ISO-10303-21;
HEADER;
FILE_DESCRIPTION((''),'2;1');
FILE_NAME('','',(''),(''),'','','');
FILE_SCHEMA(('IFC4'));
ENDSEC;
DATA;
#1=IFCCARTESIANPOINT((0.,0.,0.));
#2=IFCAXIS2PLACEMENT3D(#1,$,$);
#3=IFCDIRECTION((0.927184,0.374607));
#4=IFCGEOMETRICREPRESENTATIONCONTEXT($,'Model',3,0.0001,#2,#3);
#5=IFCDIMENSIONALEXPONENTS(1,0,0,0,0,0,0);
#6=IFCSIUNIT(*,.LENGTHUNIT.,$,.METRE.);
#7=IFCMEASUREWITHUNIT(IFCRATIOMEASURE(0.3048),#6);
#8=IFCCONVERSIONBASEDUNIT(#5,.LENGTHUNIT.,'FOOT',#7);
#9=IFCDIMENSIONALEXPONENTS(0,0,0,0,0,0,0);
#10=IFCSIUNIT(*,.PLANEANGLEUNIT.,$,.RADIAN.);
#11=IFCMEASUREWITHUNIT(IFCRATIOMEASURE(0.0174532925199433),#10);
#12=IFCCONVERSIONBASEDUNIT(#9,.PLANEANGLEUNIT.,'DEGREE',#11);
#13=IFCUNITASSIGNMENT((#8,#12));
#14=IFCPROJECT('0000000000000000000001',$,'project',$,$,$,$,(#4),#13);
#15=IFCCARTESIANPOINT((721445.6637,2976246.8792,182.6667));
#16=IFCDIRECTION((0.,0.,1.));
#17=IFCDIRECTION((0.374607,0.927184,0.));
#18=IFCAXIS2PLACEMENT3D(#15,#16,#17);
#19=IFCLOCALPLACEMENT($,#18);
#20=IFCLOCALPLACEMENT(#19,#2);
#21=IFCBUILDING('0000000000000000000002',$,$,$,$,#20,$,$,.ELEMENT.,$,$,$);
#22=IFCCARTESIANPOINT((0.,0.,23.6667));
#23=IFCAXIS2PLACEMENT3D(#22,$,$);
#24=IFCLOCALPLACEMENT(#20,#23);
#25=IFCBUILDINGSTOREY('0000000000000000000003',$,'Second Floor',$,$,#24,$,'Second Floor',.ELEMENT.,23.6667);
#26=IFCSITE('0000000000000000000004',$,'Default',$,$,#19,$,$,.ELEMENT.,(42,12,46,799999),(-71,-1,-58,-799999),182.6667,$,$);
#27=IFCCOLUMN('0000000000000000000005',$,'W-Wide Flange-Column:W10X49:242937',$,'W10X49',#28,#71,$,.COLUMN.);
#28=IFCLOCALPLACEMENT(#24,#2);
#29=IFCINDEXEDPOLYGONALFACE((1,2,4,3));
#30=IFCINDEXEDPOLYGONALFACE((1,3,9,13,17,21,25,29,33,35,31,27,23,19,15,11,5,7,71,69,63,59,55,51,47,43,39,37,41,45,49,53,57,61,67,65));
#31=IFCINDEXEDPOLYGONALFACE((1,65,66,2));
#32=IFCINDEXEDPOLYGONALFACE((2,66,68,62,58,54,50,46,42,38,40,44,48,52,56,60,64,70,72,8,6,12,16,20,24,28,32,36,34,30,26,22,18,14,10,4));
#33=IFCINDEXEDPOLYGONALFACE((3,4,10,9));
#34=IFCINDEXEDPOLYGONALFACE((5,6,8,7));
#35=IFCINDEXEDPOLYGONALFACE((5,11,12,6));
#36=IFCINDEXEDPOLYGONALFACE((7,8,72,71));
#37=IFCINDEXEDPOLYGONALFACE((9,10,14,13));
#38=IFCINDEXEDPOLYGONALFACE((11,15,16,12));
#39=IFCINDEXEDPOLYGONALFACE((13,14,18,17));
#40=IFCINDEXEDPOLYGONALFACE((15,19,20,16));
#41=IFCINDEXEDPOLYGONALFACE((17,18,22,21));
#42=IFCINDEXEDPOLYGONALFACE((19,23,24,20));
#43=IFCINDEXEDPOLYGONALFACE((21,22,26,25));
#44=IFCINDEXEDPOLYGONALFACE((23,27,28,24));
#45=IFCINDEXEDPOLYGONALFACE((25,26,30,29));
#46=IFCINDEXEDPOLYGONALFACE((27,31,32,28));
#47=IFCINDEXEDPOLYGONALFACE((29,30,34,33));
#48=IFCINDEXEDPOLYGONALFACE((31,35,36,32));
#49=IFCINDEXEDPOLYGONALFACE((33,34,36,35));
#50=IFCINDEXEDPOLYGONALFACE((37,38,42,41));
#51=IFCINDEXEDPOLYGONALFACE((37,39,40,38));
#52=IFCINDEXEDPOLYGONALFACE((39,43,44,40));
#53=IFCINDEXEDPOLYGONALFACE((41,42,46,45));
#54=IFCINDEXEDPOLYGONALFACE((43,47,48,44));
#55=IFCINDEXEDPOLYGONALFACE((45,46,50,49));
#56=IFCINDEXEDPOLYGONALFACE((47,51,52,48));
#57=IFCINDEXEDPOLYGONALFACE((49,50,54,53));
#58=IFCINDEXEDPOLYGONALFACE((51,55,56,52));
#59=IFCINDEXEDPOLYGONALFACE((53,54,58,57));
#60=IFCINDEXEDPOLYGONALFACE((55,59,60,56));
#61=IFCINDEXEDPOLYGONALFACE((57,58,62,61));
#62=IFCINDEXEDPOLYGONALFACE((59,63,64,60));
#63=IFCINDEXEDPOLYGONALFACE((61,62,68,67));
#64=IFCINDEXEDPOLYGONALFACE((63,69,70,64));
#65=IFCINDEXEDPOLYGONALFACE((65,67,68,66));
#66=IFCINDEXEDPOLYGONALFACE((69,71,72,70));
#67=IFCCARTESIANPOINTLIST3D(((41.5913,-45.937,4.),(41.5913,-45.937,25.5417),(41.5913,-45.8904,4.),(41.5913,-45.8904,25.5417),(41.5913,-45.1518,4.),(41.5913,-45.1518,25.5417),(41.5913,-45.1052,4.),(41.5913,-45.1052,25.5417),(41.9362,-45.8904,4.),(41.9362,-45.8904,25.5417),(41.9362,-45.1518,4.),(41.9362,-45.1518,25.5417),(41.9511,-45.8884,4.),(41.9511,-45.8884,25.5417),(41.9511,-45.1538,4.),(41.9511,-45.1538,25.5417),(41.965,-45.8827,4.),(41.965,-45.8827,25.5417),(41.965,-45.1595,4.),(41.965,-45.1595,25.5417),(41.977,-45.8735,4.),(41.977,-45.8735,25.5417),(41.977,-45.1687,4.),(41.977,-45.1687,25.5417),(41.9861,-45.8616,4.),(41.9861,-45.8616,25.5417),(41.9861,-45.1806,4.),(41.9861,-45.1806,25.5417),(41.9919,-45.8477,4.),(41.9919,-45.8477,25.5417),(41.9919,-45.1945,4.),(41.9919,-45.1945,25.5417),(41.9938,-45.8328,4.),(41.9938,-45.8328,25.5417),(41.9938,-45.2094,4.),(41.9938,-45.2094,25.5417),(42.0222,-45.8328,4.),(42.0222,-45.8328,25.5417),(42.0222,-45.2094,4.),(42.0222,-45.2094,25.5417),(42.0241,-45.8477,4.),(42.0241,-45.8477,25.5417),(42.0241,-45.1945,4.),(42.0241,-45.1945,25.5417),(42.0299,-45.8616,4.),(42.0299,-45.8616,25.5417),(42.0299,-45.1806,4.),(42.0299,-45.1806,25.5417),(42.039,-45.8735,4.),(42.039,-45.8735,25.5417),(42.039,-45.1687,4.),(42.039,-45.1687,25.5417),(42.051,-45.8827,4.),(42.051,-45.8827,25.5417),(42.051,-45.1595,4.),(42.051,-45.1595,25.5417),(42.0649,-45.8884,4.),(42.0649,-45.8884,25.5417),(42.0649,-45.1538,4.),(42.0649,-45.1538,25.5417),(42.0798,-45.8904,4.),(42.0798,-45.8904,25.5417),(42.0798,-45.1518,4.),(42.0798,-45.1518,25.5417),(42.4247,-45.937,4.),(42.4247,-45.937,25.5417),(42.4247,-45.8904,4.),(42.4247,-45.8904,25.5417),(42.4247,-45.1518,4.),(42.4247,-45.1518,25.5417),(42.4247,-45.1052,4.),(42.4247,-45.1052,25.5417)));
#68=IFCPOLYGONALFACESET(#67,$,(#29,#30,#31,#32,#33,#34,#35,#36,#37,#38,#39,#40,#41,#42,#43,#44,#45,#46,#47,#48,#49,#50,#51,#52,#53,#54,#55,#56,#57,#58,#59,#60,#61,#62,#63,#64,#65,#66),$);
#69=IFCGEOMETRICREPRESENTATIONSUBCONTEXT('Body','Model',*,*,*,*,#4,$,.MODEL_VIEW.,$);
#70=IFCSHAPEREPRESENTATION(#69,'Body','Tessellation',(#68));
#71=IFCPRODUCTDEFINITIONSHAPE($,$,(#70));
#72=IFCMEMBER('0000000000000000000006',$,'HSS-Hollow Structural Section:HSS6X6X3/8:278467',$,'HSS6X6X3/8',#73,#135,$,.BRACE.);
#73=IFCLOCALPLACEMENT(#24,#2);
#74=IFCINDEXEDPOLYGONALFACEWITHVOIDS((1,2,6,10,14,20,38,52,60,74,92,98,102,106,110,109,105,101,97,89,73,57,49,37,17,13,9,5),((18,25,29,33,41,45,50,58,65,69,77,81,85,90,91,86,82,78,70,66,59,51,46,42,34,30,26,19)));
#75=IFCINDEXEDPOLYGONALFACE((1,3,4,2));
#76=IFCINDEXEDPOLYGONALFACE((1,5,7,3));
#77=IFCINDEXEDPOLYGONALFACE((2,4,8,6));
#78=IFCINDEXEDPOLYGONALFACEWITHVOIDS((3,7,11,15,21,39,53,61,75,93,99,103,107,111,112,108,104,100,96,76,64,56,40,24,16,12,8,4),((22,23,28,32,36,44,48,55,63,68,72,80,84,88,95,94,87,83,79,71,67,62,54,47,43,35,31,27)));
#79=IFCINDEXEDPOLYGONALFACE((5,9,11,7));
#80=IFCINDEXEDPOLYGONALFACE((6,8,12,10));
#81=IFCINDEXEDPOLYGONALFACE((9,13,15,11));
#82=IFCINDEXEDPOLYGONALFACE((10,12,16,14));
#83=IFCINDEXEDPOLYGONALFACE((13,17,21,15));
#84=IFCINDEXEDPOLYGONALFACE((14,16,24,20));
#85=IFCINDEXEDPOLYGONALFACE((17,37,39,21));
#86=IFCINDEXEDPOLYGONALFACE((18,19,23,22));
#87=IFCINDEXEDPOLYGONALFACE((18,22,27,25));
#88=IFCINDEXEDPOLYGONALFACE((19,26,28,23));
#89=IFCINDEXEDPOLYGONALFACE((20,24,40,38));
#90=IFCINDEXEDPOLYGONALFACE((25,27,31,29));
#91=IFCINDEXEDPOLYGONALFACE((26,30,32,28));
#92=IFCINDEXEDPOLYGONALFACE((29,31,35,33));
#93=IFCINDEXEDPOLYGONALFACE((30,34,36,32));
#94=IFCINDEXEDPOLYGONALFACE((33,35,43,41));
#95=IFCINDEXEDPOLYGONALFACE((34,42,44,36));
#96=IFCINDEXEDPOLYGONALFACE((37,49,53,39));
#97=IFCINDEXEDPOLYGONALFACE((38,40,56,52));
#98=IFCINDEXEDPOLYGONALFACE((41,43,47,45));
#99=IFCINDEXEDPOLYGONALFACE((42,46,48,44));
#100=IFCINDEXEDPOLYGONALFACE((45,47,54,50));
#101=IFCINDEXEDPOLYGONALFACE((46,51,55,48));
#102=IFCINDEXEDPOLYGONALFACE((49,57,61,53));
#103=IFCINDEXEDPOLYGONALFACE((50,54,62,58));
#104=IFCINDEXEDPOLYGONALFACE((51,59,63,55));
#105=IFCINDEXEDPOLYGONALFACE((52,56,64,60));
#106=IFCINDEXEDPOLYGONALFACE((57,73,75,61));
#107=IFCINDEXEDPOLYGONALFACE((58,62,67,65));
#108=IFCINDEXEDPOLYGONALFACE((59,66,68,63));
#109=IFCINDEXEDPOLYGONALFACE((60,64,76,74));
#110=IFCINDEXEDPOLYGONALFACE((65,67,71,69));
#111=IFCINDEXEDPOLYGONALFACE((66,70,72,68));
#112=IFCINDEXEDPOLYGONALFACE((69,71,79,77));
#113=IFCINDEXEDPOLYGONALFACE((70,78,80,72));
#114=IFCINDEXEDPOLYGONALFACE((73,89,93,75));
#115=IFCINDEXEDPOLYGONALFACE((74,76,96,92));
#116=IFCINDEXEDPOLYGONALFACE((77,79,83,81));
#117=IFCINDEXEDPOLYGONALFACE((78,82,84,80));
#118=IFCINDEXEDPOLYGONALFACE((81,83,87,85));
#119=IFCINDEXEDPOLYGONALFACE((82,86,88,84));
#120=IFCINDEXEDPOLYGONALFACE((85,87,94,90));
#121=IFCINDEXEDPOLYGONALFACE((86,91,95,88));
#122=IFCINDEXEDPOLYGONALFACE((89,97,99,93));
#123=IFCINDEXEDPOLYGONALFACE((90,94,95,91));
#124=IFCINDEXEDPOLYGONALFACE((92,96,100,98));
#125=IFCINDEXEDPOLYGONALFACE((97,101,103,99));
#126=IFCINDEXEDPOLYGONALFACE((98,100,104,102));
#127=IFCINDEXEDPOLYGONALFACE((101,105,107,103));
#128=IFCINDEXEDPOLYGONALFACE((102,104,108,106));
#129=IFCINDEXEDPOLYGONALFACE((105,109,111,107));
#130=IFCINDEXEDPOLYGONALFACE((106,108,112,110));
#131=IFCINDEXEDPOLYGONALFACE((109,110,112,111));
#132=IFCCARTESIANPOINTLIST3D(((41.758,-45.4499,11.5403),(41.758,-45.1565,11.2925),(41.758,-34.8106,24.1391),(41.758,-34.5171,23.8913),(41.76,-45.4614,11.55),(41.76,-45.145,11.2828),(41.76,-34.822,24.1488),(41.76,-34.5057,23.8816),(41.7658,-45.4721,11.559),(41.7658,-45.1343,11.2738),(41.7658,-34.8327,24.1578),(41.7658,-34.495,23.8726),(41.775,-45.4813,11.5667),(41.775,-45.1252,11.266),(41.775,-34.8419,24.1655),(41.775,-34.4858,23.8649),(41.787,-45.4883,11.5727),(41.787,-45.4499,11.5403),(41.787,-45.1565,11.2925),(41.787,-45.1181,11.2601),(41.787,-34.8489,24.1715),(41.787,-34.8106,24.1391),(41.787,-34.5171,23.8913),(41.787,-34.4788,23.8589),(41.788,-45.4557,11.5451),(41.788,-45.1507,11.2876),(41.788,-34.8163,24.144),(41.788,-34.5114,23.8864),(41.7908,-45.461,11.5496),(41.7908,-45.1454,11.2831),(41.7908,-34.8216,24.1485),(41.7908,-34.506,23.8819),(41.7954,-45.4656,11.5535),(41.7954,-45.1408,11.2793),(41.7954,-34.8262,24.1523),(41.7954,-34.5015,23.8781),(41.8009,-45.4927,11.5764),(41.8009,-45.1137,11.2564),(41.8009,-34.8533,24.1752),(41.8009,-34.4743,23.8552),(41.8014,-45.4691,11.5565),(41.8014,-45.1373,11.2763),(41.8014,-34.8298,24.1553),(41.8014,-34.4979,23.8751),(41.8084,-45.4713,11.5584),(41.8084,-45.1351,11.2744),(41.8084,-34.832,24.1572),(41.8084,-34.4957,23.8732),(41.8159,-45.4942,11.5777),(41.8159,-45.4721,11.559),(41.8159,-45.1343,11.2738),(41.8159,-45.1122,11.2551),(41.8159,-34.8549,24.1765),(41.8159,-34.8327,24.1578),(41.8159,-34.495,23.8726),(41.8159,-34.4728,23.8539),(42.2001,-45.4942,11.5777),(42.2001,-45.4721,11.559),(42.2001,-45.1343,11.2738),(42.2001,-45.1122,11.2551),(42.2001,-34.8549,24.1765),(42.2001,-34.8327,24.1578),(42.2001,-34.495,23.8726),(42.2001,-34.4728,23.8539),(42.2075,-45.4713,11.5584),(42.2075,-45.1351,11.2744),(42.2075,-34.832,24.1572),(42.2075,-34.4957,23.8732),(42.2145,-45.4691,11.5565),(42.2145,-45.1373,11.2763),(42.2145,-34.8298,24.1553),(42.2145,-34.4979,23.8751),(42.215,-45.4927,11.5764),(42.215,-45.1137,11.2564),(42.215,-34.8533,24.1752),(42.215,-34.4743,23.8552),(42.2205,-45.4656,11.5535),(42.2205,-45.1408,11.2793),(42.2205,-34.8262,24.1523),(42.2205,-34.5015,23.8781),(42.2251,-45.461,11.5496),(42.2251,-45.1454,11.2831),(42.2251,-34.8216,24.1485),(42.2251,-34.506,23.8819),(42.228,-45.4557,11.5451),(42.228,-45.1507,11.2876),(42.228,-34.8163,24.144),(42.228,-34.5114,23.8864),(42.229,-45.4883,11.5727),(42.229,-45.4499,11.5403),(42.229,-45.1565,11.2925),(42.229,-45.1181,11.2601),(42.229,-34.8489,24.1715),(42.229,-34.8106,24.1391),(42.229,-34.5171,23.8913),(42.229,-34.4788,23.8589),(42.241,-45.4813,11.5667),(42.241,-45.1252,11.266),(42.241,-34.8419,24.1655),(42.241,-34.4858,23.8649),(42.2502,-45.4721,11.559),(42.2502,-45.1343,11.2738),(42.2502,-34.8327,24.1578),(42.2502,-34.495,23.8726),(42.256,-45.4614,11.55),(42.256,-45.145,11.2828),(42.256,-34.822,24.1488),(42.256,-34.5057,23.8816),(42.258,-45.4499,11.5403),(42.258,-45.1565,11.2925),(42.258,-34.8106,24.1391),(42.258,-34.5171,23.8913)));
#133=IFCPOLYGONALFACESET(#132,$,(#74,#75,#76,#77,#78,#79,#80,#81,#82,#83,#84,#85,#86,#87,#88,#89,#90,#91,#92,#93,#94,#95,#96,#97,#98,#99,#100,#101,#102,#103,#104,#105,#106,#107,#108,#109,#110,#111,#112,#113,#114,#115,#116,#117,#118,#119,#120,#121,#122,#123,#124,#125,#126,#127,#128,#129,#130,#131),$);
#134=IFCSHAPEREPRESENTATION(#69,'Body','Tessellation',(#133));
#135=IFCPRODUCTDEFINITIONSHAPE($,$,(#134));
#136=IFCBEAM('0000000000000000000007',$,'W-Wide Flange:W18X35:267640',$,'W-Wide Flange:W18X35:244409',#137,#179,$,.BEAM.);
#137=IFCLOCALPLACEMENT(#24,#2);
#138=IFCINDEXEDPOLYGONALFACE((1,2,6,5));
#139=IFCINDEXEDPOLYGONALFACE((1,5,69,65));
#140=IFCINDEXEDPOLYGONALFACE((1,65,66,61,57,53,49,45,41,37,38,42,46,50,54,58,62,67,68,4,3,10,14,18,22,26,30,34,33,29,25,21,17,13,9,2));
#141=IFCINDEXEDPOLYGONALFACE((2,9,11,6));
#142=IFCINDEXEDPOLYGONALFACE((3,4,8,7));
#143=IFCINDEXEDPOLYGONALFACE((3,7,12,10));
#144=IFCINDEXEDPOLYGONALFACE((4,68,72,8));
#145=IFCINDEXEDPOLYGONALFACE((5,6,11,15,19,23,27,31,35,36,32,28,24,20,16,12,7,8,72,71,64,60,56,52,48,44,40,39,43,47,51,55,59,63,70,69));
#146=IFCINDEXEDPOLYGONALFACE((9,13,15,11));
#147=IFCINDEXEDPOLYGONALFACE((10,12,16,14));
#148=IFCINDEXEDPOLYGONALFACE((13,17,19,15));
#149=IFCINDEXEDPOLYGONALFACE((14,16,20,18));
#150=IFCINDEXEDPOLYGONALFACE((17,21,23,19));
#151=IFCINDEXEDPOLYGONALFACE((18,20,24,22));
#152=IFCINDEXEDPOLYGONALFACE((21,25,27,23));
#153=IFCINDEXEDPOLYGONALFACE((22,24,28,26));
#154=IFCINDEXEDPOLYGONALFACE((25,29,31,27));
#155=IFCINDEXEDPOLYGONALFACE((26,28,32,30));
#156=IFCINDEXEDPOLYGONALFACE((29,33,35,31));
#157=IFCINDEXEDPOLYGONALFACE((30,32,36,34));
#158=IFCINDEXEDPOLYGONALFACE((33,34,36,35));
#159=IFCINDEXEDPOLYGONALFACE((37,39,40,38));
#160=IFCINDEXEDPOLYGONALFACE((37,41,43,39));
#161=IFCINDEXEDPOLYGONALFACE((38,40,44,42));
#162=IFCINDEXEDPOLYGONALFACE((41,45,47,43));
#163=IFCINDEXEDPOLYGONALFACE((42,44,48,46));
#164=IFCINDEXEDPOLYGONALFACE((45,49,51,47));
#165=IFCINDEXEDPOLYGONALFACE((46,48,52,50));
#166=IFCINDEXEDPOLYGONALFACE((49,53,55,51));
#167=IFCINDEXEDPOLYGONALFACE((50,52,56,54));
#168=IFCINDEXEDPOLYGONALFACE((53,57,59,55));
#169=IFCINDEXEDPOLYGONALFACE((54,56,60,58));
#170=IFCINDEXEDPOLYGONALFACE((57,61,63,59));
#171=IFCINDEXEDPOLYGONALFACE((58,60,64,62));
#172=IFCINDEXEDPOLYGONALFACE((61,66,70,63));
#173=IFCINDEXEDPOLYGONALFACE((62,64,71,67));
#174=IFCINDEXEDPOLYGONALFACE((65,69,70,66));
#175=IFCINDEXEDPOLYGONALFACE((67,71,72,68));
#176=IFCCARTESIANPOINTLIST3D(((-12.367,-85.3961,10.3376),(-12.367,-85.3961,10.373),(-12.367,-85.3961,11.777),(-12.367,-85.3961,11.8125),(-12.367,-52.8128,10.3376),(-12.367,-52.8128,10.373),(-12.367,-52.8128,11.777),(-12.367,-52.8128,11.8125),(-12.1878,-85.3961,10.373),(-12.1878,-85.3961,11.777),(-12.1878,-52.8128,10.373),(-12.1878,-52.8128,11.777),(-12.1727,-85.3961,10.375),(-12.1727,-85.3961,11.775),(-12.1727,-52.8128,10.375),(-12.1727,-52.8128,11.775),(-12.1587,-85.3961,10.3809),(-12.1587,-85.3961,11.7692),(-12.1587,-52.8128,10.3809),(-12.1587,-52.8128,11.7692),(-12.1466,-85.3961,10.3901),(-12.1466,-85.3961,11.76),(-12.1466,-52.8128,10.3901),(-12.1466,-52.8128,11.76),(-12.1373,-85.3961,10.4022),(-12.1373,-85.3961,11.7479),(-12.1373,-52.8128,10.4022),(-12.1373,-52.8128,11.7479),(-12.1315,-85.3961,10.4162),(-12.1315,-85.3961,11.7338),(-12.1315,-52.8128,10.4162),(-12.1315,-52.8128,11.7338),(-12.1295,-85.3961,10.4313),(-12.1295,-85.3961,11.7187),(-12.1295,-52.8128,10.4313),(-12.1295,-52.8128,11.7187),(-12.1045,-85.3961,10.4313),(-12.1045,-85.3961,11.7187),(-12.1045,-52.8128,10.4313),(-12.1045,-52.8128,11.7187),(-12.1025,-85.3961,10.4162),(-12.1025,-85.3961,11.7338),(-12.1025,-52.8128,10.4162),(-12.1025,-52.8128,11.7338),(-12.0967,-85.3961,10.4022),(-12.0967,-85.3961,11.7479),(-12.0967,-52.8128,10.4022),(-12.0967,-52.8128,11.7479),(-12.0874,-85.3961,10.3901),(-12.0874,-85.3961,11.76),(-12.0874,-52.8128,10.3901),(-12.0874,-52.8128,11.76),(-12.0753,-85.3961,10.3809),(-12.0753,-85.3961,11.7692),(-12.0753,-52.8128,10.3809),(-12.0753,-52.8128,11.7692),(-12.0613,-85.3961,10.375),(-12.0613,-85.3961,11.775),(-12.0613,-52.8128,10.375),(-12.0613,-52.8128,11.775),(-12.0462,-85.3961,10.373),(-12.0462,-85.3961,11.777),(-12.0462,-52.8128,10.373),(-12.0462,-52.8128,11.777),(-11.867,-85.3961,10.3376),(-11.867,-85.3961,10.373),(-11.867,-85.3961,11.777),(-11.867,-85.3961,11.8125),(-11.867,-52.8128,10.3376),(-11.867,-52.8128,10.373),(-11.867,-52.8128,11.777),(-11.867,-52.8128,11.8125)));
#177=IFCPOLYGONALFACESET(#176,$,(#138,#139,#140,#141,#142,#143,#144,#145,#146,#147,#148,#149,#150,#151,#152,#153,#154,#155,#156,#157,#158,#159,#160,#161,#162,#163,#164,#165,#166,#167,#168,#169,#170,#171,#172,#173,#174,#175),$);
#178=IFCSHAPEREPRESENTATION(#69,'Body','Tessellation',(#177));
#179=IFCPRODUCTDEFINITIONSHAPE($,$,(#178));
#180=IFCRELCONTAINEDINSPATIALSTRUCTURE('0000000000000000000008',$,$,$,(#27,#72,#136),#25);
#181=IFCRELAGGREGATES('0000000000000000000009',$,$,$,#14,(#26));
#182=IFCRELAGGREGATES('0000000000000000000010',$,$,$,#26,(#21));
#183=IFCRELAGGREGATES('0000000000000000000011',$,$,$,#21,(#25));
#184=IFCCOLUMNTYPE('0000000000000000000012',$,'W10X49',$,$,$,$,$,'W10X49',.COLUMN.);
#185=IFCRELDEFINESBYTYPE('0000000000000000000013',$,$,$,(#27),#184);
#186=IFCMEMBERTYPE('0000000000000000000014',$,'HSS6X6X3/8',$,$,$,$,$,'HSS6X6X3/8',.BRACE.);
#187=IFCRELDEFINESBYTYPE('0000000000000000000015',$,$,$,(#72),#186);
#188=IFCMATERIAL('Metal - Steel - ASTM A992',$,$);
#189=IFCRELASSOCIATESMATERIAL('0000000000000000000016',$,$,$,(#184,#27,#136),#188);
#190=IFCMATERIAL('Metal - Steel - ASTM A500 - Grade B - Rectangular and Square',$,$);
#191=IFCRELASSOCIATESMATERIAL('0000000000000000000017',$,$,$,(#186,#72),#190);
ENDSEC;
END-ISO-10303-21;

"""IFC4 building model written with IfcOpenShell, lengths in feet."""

from ifc_helpers import new_model, entity, si_unit, converted_unit, direction, frame, frame_2d, origin, place, context, subcontext, project, spatial, polyline, circle_curve, parameter, trimmed, segment, composite_curve, i_section, outline, extrude, source, transform, mapped, material, type_object, type_shapes, element, save


model = new_model("IFC4")

# Units and contexts
model_context = context("Model", 3, precision=0.0001, world=origin(), true_north=direction((0.927184, 0.374607)))
body_context = subcontext(model_context, "Body", "Model", "MODEL_VIEW")
ifc_project = project(units=[converted_unit("LENGTHUNIT", "FOOT", entity("IfcRatioMeasure", 0.3048), si_unit("LENGTHUNIT", "METRE"), dimensions=[1, 0, 0, 0, 0, 0, 0]), converted_unit("PLANEANGLEUNIT", "DEGREE", entity("IfcRatioMeasure", 0.0174532925199433), si_unit("PLANEANGLEUNIT", "RADIAN"), dimensions=[0, 0, 0, 0, 0, 0, 0])], contexts=[model_context])

# Site, building, storey
site_placement = place(None, frame((721445.6637, 2976246.8792, 182.6667), z_axis=(0.0, 0.0, 1.0), x_axis=(0.374607, 0.927184, 0.0)))
site = spatial("IfcSite", under=ifc_project, at=site_placement, Name="Default", CompositionType="ELEMENT", RefLatitude=(42, 12, 46, 799999), RefLongitude=(-71, -1, -58, -799999), RefElevation=182.6667)
building_placement = place(site_placement, origin())
building = spatial("IfcBuilding", under=site, at=building_placement, CompositionType="ELEMENT")
storey_placement = place(building_placement, frame((0.0, 0.0, 23.6667)))
storey = spatial("IfcBuildingStorey", under=building, at=storey_placement, Name="Second Floor", LongName="Second Floor", CompositionType="ELEMENT", Elevation=23.6667)

# Column
ifc_material_1 = material(Name="Metal - Steel - ASTM A992")
column_type = type_object("IfcColumnType", Name="W10X49", ElementType="W10X49", PredefinedType="COLUMN", material=ifc_material_1)
shared_shape_1 = source(origin(), body_context, "Body", "SweptSolid", [
    extrude(i_section(OverallWidth=0.8333, OverallDepth=0.8317, WebThickness=0.0283, FlangeThickness=0.0465, FilletRadius=0.0576, at=frame_2d((0.0, 0.0), x_axis=(0.0, 1.0))), frame((0.0, 0.0, 27.6667), z_axis=(0.0, 0.0, 1.0), x_axis=(0.0, -1.0, 0.0)), (0.0, 0.0, 1.0), 21.5417),
])
type_shapes(column_type, [shared_shape_1])
for number, where, z_axis, x_axis, name in (
    (1, (42.008, -45.5211, -23.6667), (0.0, 0.0, 1.0), (-1.0, 0.0, 0.0), "W-Wide Flange-Column:W10X49:242937"),
):
    element("IfcColumn", number, at=place(storey_placement, frame(where, z_axis=z_axis, x_axis=x_axis)), inside=storey, type_object=column_type, material=ifc_material_1, Name=name, ObjectType="W10X49", PredefinedType="COLUMN", context=body_context, shape_type="MappedRepresentation", body=[
        mapped(shared_shape_1, transform((0.0, 0.0, 0.0), scale=1.0)),
    ])

# Member
ifc_material_2 = material(Name="Metal - Steel - ASTM A500 - Grade B - Rectangular and Square")
member_type = type_object("IfcMemberType", Name="HSS6X6X3/8", ElementType="HSS6X6X3/8", PredefinedType="BRACE", material=ifc_material_2)
shared_shape_2 = source(origin(), body_context, "Body", "SweptSolid", [
    extrude(outline(composite_curve([segment(trimmed(circle_curve(frame_2d((-0.1921, -0.1921), x_axis=(1.0, 0.0)), 0.0579), [parameter(180.0)], [parameter(270.0)], True, "PARAMETER"), True, "CONTINUOUS"), segment(polyline([(-0.1921, -0.25), (0.1921, -0.25)]), True, "CONTINUOUS"), segment(trimmed(circle_curve(frame_2d((0.1921, -0.1921), x_axis=(1.0, 0.0)), 0.0579), [parameter(270.0)], [parameter(0.0)], True, "PARAMETER"), True, "CONTINUOUS"), segment(polyline([(0.25, -0.1921), (0.25, 0.1921)]), True, "CONTINUOUS"), segment(trimmed(circle_curve(frame_2d((0.1921, 0.1921), x_axis=(1.0, 0.0)), 0.0579), [parameter(360.0)], [parameter(90.0)], True, "PARAMETER"), True, "CONTINUOUS"), segment(polyline([(0.1921, 0.25), (-0.1921, 0.25)]), True, "CONTINUOUS"), segment(trimmed(circle_curve(frame_2d((-0.1921, 0.1921), x_axis=(1.0, 0.0)), 0.0579), [parameter(90.0)], [parameter(180.0)], True, "PARAMETER"), True, "CONTINUOUS"), segment(polyline([(-0.25, 0.1921), (-0.25, -0.1921)]), True, "CONTINUOUS")], self_intersect=False), holes=[composite_curve([segment(polyline([(0.1921, -0.221), (-0.1921, -0.221)]), True, "CONTINUOUS"), segment(trimmed(circle_curve(frame_2d((-0.1921, -0.1921), x_axis=(1.0, 0.0)), 0.029), [parameter(180.0)], [parameter(270.0)], True, "PARAMETER"), False, "CONTINUOUS"), segment(polyline([(-0.221, -0.1921), (-0.221, 0.1921)]), True, "CONTINUOUS"), segment(trimmed(circle_curve(frame_2d((-0.1921, 0.1921), x_axis=(1.0, 0.0)), 0.029), [parameter(90.0)], [parameter(180.0)], True, "PARAMETER"), False, "CONTINUOUS"), segment(polyline([(-0.1921, 0.221), (0.1921, 0.221)]), True, "CONTINUOUS"), segment(trimmed(circle_curve(frame_2d((0.1921, 0.1921), x_axis=(1.0, 0.0)), 0.029), [parameter(0.0)], [parameter(90.0)], True, "PARAMETER"), False, "CONTINUOUS"), segment(polyline([(0.221, 0.1921), (0.221, -0.1921)]), True, "CONTINUOUS"), segment(trimmed(circle_curve(frame_2d((0.1921, -0.1921), x_axis=(1.0, 0.0)), 0.029), [parameter(270.0)], [parameter(0.0)], True, "PARAMETER"), False, "CONTINUOUS")], self_intersect=False)]), frame((-8.6389, 0.0, 0.0), z_axis=(1.0, 0.0, 0.0), x_axis=(0.0, -1.0, 0.0)), (0.0, 0.0, 1.0), 16.4902),
])
type_shapes(member_type, [shared_shape_2])
member_placement = place(storey_placement, frame((42.008, -39.7294, 18.0167), z_axis=(0.0, -0.764019, 0.645194), x_axis=(0.0, 0.645194, 0.764019)))
element("IfcMember", 2, at=member_placement, inside=storey, type_object=member_type, material=ifc_material_2, Name="HSS-Hollow Structural Section:HSS6X6X3/8:278467", ObjectType="HSS6X6X3/8", PredefinedType="BRACE", context=body_context, shape_type="MappedRepresentation", body=[
    mapped(shared_shape_2, transform((0.0, 0.0, 0.0), scale=1.0)),
])

# Beam
beam_1_placement = place(storey_placement, frame((-12.117, -52.3544, 11.8125), z_axis=(0.0, 0.0, 1.0), x_axis=(0.0, -1.0, 0.0)))
element("IfcBeam", 3, at=beam_1_placement, inside=storey, material=ifc_material_1, Name="W-Wide Flange:W18X35:267640", ObjectType="W-Wide Flange:W18X35:244409", PredefinedType="BEAM", context=body_context, shape_type="SweptSolid", body=[
    extrude(i_section(OverallWidth=0.5, OverallDepth=1.4749, WebThickness=0.0251, FlangeThickness=0.0355, FilletRadius=0.0583, at=frame_2d((0.0, 0.0), x_axis=(0.0, 1.0))), frame((0.4583, 0.0, -0.7375), z_axis=(1.0, 0.0, 0.0), x_axis=(0.0, 0.0, -1.0)), (0.0, 0.0, 1.0), 32.5833),
])

save(model, "model.ifc")
